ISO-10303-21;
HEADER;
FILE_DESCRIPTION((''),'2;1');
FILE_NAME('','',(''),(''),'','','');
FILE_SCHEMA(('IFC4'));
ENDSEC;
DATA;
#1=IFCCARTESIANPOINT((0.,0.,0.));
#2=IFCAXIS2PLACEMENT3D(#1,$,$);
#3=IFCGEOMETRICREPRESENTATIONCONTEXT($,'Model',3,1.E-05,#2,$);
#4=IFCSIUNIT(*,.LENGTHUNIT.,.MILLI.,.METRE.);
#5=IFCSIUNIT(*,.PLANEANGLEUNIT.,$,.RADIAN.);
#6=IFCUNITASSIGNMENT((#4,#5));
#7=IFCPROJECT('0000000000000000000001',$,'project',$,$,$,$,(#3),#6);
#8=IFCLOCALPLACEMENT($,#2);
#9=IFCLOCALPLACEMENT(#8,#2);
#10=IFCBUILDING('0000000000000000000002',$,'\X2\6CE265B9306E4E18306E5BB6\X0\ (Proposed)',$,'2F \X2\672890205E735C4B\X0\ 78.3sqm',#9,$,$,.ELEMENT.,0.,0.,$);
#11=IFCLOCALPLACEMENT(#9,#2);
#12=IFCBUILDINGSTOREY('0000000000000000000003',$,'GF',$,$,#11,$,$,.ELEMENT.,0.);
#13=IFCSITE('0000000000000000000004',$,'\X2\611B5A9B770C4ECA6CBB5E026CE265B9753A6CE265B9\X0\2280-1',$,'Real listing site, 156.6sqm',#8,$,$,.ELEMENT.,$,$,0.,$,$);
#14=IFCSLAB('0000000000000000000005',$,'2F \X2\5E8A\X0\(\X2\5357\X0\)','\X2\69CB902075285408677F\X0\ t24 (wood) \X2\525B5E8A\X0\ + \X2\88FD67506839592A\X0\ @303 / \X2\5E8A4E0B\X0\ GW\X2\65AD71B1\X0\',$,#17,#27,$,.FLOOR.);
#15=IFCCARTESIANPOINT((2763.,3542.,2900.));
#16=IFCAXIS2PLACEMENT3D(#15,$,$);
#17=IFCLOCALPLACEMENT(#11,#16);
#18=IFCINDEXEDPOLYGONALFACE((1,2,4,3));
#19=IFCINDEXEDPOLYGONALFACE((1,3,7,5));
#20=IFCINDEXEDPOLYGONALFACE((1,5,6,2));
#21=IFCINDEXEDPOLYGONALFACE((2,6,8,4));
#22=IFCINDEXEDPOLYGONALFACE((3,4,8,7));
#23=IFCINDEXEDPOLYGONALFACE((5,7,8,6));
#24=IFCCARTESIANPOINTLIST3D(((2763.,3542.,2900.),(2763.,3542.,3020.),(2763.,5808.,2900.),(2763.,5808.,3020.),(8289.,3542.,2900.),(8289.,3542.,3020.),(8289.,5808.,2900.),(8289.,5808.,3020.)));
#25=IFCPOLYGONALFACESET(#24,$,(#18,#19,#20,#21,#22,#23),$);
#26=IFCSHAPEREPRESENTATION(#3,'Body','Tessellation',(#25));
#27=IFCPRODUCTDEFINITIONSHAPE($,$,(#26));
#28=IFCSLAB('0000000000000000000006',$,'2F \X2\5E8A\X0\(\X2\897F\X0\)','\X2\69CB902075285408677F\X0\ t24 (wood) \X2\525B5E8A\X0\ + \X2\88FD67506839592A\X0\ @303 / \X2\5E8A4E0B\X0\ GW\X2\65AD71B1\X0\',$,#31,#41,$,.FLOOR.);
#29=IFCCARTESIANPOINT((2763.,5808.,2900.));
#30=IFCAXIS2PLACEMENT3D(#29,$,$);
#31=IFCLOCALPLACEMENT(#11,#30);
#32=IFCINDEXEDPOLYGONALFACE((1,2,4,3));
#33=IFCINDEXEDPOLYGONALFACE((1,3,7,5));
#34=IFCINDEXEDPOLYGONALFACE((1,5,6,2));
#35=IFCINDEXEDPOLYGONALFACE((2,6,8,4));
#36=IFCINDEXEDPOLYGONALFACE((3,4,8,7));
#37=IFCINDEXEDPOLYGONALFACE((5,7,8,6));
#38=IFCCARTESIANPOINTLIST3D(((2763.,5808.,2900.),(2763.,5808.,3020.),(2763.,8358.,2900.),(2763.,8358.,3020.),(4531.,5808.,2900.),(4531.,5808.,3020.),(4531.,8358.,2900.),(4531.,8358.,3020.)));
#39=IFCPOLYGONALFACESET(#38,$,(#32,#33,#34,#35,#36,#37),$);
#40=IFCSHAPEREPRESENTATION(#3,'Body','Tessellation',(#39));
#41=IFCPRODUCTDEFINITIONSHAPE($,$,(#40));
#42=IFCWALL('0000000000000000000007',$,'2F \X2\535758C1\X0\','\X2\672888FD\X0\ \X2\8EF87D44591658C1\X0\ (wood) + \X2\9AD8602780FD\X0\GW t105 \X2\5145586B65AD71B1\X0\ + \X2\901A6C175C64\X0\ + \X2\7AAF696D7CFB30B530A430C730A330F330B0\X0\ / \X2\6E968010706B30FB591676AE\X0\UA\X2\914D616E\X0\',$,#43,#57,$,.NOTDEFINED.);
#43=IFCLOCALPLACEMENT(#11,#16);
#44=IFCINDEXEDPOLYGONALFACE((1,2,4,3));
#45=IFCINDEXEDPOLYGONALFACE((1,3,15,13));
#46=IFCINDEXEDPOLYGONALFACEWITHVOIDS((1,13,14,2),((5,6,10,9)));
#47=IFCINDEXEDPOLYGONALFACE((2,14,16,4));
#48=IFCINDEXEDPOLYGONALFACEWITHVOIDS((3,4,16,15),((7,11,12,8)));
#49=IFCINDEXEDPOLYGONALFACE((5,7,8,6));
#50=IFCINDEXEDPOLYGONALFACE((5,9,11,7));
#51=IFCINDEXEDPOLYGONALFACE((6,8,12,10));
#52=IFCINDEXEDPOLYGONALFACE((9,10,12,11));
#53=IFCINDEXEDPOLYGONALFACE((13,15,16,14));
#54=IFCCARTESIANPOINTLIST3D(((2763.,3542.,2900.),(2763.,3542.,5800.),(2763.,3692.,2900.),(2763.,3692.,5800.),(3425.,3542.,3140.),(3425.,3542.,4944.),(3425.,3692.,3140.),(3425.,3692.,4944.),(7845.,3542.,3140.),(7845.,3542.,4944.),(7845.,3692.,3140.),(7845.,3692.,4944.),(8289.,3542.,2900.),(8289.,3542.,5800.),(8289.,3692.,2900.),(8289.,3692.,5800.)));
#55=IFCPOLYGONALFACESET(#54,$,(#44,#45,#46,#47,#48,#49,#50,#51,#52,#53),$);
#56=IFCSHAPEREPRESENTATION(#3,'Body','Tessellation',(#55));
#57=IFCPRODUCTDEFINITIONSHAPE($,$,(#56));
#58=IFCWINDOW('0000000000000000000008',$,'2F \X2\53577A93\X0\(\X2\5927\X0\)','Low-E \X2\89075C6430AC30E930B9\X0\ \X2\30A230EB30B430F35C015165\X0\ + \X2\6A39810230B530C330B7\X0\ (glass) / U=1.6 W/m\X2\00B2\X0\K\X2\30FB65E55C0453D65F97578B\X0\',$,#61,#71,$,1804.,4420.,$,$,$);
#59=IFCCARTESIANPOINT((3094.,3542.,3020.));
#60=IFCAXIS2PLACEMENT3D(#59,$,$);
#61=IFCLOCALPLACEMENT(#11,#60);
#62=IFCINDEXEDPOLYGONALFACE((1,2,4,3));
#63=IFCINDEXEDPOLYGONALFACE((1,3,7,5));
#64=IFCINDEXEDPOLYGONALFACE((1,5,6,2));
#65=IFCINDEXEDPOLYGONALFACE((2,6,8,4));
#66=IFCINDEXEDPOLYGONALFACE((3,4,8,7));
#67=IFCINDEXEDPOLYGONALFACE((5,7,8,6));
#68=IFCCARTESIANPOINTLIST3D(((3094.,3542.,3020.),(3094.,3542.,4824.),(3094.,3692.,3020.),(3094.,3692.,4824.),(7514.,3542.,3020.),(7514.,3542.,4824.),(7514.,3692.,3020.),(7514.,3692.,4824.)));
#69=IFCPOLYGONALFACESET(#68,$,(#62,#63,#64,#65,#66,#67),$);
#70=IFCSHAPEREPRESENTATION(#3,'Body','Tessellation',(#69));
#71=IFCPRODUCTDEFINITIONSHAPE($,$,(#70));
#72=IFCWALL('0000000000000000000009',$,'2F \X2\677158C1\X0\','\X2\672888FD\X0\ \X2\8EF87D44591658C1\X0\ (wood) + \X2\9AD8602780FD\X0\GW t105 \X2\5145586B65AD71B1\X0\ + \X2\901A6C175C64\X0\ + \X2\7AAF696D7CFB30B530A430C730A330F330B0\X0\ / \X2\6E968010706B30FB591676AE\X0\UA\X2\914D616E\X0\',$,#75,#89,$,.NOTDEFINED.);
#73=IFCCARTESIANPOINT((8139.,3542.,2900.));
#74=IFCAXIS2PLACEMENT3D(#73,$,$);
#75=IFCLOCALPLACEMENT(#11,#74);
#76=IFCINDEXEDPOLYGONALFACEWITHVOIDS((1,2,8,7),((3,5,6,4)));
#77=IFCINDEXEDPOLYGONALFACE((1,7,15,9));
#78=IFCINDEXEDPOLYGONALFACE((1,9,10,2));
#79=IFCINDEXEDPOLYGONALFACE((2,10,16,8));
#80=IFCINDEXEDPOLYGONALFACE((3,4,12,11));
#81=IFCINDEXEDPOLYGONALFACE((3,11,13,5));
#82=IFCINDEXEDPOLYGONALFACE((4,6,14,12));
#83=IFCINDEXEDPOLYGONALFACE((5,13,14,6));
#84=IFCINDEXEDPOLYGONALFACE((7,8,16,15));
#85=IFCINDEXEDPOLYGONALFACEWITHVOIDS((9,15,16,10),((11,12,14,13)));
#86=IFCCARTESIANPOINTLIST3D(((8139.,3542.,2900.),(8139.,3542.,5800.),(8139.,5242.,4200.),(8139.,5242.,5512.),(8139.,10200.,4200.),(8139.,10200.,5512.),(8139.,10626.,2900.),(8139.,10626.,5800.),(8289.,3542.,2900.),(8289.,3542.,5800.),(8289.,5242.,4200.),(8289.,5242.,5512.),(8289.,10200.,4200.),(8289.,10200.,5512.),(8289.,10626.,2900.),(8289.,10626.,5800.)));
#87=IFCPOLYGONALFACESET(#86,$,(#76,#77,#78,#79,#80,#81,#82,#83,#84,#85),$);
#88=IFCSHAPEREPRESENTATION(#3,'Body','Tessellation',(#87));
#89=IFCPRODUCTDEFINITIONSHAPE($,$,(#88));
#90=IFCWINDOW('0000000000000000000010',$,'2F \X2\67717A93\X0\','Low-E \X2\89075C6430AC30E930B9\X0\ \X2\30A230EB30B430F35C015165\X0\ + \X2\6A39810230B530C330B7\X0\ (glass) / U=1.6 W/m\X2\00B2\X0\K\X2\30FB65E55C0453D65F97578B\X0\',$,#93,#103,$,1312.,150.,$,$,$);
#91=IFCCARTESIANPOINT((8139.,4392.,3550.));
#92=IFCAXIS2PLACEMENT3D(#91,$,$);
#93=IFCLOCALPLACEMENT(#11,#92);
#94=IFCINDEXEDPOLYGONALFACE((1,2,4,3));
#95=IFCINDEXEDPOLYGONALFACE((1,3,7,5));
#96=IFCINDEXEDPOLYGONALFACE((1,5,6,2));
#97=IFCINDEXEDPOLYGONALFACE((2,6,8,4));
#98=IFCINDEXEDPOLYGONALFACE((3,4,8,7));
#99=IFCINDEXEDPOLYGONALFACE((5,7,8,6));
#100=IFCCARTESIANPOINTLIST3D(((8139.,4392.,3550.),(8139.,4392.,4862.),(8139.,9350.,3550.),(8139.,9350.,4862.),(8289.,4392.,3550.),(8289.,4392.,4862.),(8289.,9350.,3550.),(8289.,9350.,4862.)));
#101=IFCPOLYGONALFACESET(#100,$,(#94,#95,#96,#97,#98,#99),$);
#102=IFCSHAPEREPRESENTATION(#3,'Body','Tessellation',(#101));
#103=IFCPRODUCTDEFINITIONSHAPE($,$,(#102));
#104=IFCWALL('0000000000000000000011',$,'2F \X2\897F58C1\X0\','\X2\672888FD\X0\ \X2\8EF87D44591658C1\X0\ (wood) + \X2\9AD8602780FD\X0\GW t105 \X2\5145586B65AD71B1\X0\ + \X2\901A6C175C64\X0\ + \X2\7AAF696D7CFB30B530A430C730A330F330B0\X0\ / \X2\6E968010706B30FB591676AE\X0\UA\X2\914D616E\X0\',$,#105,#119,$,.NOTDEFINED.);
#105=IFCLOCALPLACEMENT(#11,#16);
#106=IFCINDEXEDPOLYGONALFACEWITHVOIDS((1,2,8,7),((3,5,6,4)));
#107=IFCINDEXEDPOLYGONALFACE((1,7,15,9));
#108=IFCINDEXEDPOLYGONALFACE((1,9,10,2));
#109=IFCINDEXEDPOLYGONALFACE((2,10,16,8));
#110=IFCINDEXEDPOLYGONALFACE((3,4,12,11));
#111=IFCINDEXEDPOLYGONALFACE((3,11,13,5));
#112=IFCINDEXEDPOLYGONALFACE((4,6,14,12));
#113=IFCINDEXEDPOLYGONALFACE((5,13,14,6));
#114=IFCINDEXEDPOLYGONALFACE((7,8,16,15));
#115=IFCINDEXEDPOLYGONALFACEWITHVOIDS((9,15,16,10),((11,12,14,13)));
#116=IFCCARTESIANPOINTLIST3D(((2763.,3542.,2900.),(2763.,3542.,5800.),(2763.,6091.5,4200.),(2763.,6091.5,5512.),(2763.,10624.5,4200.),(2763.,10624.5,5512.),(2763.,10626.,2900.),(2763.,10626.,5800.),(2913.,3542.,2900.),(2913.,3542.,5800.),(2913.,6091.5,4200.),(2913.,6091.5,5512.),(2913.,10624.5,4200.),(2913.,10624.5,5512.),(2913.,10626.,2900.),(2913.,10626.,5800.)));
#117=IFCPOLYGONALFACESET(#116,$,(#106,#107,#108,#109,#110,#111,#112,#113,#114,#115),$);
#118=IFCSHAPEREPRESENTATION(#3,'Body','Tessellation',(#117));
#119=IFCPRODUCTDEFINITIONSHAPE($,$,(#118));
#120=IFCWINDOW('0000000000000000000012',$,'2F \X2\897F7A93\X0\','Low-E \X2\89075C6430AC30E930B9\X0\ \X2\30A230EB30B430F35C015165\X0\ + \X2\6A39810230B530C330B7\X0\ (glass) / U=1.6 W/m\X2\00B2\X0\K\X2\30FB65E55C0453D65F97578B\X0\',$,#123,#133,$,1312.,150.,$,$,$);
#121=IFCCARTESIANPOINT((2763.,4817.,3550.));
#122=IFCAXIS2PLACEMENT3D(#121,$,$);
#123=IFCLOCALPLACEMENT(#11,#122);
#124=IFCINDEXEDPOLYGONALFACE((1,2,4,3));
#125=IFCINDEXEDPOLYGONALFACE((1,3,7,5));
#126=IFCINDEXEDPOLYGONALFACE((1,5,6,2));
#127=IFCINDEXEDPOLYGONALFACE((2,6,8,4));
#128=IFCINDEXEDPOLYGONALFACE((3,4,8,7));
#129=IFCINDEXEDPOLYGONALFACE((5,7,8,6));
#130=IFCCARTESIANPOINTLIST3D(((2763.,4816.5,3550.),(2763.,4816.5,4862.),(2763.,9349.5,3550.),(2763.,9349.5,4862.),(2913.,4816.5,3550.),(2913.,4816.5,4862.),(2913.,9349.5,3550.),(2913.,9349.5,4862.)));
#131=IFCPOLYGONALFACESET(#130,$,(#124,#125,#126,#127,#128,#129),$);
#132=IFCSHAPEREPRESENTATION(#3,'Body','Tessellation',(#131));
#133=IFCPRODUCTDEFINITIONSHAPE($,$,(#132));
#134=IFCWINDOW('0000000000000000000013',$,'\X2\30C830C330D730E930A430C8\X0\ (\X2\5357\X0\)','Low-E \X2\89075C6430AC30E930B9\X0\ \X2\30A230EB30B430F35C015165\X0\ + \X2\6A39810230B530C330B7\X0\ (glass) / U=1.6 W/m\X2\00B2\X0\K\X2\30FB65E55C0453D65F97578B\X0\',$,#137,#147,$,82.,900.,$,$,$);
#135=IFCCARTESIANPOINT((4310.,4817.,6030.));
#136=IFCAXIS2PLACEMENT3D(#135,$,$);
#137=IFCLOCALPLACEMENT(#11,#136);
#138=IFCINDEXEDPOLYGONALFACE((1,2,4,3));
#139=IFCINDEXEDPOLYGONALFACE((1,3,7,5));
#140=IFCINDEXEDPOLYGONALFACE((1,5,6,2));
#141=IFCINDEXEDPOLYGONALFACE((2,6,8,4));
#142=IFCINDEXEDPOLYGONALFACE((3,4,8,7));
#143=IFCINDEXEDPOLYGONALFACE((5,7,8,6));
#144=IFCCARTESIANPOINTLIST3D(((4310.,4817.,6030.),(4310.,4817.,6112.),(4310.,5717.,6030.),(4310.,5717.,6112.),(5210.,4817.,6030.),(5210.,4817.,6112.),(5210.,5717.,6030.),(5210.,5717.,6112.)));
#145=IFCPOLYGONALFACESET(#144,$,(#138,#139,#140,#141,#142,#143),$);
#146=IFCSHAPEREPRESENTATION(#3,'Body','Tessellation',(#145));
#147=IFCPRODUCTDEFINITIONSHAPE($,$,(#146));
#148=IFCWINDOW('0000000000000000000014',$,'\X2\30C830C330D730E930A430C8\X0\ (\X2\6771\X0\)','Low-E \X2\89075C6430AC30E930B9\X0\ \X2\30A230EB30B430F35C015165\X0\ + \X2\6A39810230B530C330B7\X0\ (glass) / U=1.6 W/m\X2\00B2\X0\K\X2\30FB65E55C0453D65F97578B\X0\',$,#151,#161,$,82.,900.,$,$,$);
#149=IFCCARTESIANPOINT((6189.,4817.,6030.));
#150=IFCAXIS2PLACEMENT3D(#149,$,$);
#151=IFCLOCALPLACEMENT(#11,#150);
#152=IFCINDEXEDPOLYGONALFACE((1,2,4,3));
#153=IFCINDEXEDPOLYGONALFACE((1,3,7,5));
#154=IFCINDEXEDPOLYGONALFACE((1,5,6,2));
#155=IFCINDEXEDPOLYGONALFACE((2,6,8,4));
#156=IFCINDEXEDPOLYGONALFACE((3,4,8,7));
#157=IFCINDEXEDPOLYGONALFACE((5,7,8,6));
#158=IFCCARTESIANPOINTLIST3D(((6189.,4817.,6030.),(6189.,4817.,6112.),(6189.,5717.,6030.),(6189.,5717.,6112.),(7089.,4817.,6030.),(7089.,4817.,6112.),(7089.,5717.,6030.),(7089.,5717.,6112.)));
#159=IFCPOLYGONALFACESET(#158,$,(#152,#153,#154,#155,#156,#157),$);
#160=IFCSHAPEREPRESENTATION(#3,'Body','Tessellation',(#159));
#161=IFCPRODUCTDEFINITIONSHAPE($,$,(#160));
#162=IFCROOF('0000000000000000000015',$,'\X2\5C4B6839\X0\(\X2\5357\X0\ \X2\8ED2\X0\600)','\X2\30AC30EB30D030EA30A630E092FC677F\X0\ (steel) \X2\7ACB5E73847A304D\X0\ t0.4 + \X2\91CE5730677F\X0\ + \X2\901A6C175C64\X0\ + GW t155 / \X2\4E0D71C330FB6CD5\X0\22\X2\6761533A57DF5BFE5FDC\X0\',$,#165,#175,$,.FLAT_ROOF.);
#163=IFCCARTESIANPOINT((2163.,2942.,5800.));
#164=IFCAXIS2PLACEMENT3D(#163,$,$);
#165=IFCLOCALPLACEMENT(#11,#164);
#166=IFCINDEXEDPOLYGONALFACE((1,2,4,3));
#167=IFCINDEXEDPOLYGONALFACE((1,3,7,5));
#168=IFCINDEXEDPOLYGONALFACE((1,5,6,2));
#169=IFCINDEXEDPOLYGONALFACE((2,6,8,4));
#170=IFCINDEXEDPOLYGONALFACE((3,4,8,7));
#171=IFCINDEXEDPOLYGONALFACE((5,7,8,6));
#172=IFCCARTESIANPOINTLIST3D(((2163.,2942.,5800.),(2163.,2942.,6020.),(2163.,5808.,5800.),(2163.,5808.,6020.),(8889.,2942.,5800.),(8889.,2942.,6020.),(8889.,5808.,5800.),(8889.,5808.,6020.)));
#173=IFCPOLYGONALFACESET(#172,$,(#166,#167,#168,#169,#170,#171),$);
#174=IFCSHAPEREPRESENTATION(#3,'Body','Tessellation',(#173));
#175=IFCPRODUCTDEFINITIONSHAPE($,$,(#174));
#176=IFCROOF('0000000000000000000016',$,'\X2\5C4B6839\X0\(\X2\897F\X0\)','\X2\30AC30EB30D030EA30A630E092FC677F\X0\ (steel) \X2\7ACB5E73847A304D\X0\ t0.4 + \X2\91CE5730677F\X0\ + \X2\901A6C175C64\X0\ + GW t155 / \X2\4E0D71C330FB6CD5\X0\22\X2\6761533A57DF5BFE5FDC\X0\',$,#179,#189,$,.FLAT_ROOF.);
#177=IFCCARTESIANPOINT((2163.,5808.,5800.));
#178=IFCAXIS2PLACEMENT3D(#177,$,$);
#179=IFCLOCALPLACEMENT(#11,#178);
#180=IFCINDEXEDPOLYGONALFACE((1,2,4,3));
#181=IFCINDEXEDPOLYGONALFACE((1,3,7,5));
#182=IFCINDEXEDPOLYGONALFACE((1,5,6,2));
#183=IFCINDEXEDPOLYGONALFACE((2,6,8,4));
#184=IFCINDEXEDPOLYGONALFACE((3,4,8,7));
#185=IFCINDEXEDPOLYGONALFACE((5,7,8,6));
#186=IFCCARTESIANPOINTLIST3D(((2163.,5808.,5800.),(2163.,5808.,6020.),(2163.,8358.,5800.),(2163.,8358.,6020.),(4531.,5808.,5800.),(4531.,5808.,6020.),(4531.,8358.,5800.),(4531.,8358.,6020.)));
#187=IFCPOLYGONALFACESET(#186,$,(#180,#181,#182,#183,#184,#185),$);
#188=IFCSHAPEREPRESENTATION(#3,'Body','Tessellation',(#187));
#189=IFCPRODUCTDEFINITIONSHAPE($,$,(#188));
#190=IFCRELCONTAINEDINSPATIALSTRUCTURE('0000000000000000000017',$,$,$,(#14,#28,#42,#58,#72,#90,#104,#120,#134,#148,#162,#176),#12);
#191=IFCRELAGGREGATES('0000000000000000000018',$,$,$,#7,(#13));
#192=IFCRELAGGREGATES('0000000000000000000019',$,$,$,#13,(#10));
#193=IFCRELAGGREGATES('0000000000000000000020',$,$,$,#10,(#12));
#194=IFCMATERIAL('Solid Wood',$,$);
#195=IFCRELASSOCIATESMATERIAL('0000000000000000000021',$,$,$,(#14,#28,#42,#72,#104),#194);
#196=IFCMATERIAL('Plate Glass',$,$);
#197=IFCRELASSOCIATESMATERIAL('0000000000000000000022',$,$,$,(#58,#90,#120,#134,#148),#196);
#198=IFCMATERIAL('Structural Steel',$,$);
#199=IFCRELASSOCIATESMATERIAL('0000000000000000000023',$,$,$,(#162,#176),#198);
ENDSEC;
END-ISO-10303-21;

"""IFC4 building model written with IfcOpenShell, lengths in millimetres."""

from ifc_helpers import new_model, si_unit, frame, frame_2d, origin, place, context, project, spatial, rectangle, extrude, material, element, fill, save


model = new_model("IFC4")

# Units and contexts
model_context = context("Model", 3, precision=1e-05, world=origin())
ifc_project = project(units=[si_unit("LENGTHUNIT", "METRE", prefix="MILLI"), si_unit("PLANEANGLEUNIT", "RADIAN")], contexts=[model_context])

# Site, building, storey
site_placement = place(None, origin())
site = spatial("IfcSite", under=ifc_project, at=site_placement, Name="愛媛県今治市波方町波方2280-1", ObjectType="Real listing site, 156.6sqm", CompositionType="ELEMENT", RefElevation=0.0)
building_placement = place(site_placement, origin())
building = spatial("IfcBuilding", under=site, at=building_placement, Name="波方の丘の家 (Proposed)", ObjectType="2F 木造平屋 78.3sqm", CompositionType="ELEMENT", ElevationOfRefHeight=0.0, ElevationOfTerrain=0.0)
storey_placement = place(building_placement, origin())
storey = spatial("IfcBuildingStorey", under=building, at=storey_placement, Name="GF", CompositionType="ELEMENT", Elevation=0.0)

# Slabs
ifc_material_1 = material(Name="Solid Wood")
slab_1_placement = place(storey_placement, frame((2763.0, 3542.0, 2900.0)))
element("IfcSlab", 1, at=slab_1_placement, inside=storey, material=ifc_material_1, Name="2F 床(南)", Description="構造用合板 t24 (wood) 剛床 + 製材根太 @303 / 床下 GW断熱", PredefinedType="FLOOR", context=model_context, shape_type="SweptSolid", body=[
    extrude(rectangle(XDim=5526.0, YDim=2266.0, at=frame_2d((2763.0, 1133.0))), frame((2763.0, 3542.0, 2900.0)), (0.0, 0.0, 1.0), 120.0),
])
slab_2_placement = place(storey_placement, frame((2763.0, 5808.0, 2900.0)))
element("IfcSlab", 2, at=slab_2_placement, inside=storey, material=ifc_material_1, Name="2F 床(西)", Description="構造用合板 t24 (wood) 剛床 + 製材根太 @303 / 床下 GW断熱", PredefinedType="FLOOR", context=model_context, shape_type="SweptSolid", body=[
    extrude(rectangle(XDim=1768.0, YDim=2550.0, at=frame_2d((884.0, 1275.0))), frame((2763.0, 5808.0, 2900.0)), (0.0, 0.0, 1.0), 120.0),
])

# Walls, openings, windows
wall_1_placement = place(storey_placement, frame((2763.0, 3542.0, 2900.0)))
wall_1 = element("IfcWall", 3, at=wall_1_placement, inside=storey, material=ifc_material_1, Name="2F 南壁", Description="木製 軸組外壁 (wood) + 高性能GW t105 充填断熱 + 通気層 + 窯業系サイディング / 準耐火・外皮UA配慮", PredefinedType="NOTDEFINED", context=model_context, shape_type="SweptSolid", body=[
    extrude(rectangle(XDim=5526.0, YDim=150.0, at=frame_2d((2763.0, 75.0))), frame((2763.0, 3542.0, 2900.0)), (0.0, 0.0, 1.0), 2900.0),
])
opening_1_placement = place(storey_placement, frame((3094.0, 3542.0, 3020.0)))
opening_1 = element("IfcOpeningElement", 4, at=opening_1_placement, cuts=wall_1, PredefinedType="NOTDEFINED", context=model_context, shape_type="SweptSolid", body=[
    extrude(rectangle(XDim=4420.0, YDim=150.0, at=frame_2d((2210.0, 75.0))), frame((3094.0, 3542.0, 3020.0)), (0.0, 0.0, 1.0), 1804.0),
])
ifc_material_2 = material(Name="Plate Glass")
window_1_placement = place(storey_placement, frame((3094.0, 3542.0, 3020.0)))
window_1 = element("IfcWindow", 5, at=window_1_placement, inside=storey, material=ifc_material_2, Name="2F 南窓(大)", Description="Low-E 複層ガラス アルゴン封入 + 樹脂サッシ (glass) / U=1.6 W/m²K・日射取得型", OverallHeight=1804.0, OverallWidth=4420.0, context=model_context, shape_type="SweptSolid", body=[
    extrude(rectangle(XDim=4420.0, YDim=150.0, at=frame_2d((2210.0, 75.0))), frame((3094.0, 3542.0, 3020.0)), (0.0, 0.0, 1.0), 1804.0),
])
fill(opening_1, window_1)
wall_2_placement = place(storey_placement, frame((8139.0, 3542.0, 2900.0)))
wall_2 = element("IfcWall", 6, at=wall_2_placement, inside=storey, material=ifc_material_1, Name="2F 東壁", Description="木製 軸組外壁 (wood) + 高性能GW t105 充填断熱 + 通気層 + 窯業系サイディング / 準耐火・外皮UA配慮", PredefinedType="NOTDEFINED", context=model_context, shape_type="SweptSolid", body=[
    extrude(rectangle(XDim=150.0, YDim=7084.0, at=frame_2d((75.0, 3542.0))), frame((8139.0, 3542.0, 2900.0)), (0.0, 0.0, 1.0), 2900.0),
])
opening_2_placement = place(storey_placement, frame((8139.0, 4392.0, 3550.0)))
opening_2 = element("IfcOpeningElement", 7, at=opening_2_placement, cuts=wall_2, PredefinedType="NOTDEFINED", context=model_context, shape_type="SweptSolid", body=[
    extrude(rectangle(XDim=150.0, YDim=4958.0, at=frame_2d((75.0, 2479.0))), frame((8139.0, 4392.0, 3550.0)), (0.0, 0.0, 1.0), 1312.0),
])
window_2_placement = place(storey_placement, frame((8139.0, 4392.0, 3550.0)))
window_2 = element("IfcWindow", 8, at=window_2_placement, inside=storey, material=ifc_material_2, Name="2F 東窓", Description="Low-E 複層ガラス アルゴン封入 + 樹脂サッシ (glass) / U=1.6 W/m²K・日射取得型", OverallHeight=1312.0, OverallWidth=150.0, context=model_context, shape_type="SweptSolid", body=[
    extrude(rectangle(XDim=150.0, YDim=4958.0, at=frame_2d((75.0, 2479.0))), frame((8139.0, 4392.0, 3550.0)), (0.0, 0.0, 1.0), 1312.0),
])
fill(opening_2, window_2)
wall_3_placement = place(storey_placement, frame((2763.0, 3542.0, 2900.0)))
wall_3 = element("IfcWall", 9, at=wall_3_placement, inside=storey, material=ifc_material_1, Name="2F 西壁", Description="木製 軸組外壁 (wood) + 高性能GW t105 充填断熱 + 通気層 + 窯業系サイディング / 準耐火・外皮UA配慮", PredefinedType="NOTDEFINED", context=model_context, shape_type="SweptSolid", body=[
    extrude(rectangle(XDim=150.0, YDim=7084.0, at=frame_2d((75.0, 3542.0))), frame((2763.0, 3542.0, 2900.0)), (0.0, 0.0, 1.0), 2900.0),
])
opening_3_placement = place(storey_placement, frame((2763.0, 4817.0, 3550.0)))
opening_3 = element("IfcOpeningElement", 10, at=opening_3_placement, cuts=wall_3, PredefinedType="NOTDEFINED", context=model_context, shape_type="SweptSolid", body=[
    extrude(rectangle(XDim=150.0, YDim=4533.0, at=frame_2d((75.0, 2266.0))), frame((2763.0, 4817.0, 3550.0)), (0.0, 0.0, 1.0), 1312.0),
])
window_3_placement = place(storey_placement, frame((2763.0, 4817.0, 3550.0)))
window_3 = element("IfcWindow", 11, at=window_3_placement, inside=storey, material=ifc_material_2, Name="2F 西窓", Description="Low-E 複層ガラス アルゴン封入 + 樹脂サッシ (glass) / U=1.6 W/m²K・日射取得型", OverallHeight=1312.0, OverallWidth=150.0, context=model_context, shape_type="SweptSolid", body=[
    extrude(rectangle(XDim=150.0, YDim=4533.0, at=frame_2d((75.0, 2266.0))), frame((2763.0, 4817.0, 3550.0)), (0.0, 0.0, 1.0), 1312.0),
])
fill(opening_3, window_3)

# Windows
window_4_placement = place(storey_placement, frame((4310.0, 4817.0, 6030.0)))
element("IfcWindow", 12, at=window_4_placement, inside=storey, material=ifc_material_2, Name="トップライト (南)", Description="Low-E 複層ガラス アルゴン封入 + 樹脂サッシ (glass) / U=1.6 W/m²K・日射取得型", OverallHeight=82.0, OverallWidth=900.0, context=model_context, shape_type="SweptSolid", body=[
    extrude(rectangle(XDim=900.0, YDim=900.0, at=frame_2d((450.0, 450.0))), frame((4310.0, 4817.0, 6030.0)), (0.0, 0.0, 1.0), 82.0),
])
window_5_placement = place(storey_placement, frame((6189.0, 4817.0, 6030.0)))
element("IfcWindow", 13, at=window_5_placement, inside=storey, material=ifc_material_2, Name="トップライト (東)", Description="Low-E 複層ガラス アルゴン封入 + 樹脂サッシ (glass) / U=1.6 W/m²K・日射取得型", OverallHeight=82.0, OverallWidth=900.0, context=model_context, shape_type="SweptSolid", body=[
    extrude(rectangle(XDim=900.0, YDim=900.0, at=frame_2d((450.0, 450.0))), frame((6189.0, 4817.0, 6030.0)), (0.0, 0.0, 1.0), 82.0),
])

# Roofs
ifc_material_3 = material(Name="Structural Steel")
roof_1_placement = place(storey_placement, frame((2163.0, 2942.0, 5800.0)))
element("IfcRoof", 14, at=roof_1_placement, inside=storey, material=ifc_material_3, Name="屋根(南 軒600)", Description="ガルバリウム鋼板 (steel) 立平葺き t0.4 + 野地板 + 通気層 + GW t155 / 不燃・法22条区域対応", PredefinedType="FLAT_ROOF", context=model_context, shape_type="SweptSolid", body=[
    extrude(rectangle(XDim=6726.0, YDim=2866.0, at=frame_2d((3363.0, 1433.0))), frame((2163.0, 2942.0, 5800.0)), (0.0, 0.0, 1.0), 220.0),
])
roof_2_placement = place(storey_placement, frame((2163.0, 5808.0, 5800.0)))
element("IfcRoof", 15, at=roof_2_placement, inside=storey, material=ifc_material_3, Name="屋根(西)", Description="ガルバリウム鋼板 (steel) 立平葺き t0.4 + 野地板 + 通気層 + GW t155 / 不燃・法22条区域対応", PredefinedType="FLAT_ROOF", context=model_context, shape_type="SweptSolid", body=[
    extrude(rectangle(XDim=2368.0, YDim=2550.0, at=frame_2d((1184.0, 1275.0))), frame((2163.0, 5808.0, 5800.0)), (0.0, 0.0, 1.0), 220.0),
])

save(model, "model.ifc")
